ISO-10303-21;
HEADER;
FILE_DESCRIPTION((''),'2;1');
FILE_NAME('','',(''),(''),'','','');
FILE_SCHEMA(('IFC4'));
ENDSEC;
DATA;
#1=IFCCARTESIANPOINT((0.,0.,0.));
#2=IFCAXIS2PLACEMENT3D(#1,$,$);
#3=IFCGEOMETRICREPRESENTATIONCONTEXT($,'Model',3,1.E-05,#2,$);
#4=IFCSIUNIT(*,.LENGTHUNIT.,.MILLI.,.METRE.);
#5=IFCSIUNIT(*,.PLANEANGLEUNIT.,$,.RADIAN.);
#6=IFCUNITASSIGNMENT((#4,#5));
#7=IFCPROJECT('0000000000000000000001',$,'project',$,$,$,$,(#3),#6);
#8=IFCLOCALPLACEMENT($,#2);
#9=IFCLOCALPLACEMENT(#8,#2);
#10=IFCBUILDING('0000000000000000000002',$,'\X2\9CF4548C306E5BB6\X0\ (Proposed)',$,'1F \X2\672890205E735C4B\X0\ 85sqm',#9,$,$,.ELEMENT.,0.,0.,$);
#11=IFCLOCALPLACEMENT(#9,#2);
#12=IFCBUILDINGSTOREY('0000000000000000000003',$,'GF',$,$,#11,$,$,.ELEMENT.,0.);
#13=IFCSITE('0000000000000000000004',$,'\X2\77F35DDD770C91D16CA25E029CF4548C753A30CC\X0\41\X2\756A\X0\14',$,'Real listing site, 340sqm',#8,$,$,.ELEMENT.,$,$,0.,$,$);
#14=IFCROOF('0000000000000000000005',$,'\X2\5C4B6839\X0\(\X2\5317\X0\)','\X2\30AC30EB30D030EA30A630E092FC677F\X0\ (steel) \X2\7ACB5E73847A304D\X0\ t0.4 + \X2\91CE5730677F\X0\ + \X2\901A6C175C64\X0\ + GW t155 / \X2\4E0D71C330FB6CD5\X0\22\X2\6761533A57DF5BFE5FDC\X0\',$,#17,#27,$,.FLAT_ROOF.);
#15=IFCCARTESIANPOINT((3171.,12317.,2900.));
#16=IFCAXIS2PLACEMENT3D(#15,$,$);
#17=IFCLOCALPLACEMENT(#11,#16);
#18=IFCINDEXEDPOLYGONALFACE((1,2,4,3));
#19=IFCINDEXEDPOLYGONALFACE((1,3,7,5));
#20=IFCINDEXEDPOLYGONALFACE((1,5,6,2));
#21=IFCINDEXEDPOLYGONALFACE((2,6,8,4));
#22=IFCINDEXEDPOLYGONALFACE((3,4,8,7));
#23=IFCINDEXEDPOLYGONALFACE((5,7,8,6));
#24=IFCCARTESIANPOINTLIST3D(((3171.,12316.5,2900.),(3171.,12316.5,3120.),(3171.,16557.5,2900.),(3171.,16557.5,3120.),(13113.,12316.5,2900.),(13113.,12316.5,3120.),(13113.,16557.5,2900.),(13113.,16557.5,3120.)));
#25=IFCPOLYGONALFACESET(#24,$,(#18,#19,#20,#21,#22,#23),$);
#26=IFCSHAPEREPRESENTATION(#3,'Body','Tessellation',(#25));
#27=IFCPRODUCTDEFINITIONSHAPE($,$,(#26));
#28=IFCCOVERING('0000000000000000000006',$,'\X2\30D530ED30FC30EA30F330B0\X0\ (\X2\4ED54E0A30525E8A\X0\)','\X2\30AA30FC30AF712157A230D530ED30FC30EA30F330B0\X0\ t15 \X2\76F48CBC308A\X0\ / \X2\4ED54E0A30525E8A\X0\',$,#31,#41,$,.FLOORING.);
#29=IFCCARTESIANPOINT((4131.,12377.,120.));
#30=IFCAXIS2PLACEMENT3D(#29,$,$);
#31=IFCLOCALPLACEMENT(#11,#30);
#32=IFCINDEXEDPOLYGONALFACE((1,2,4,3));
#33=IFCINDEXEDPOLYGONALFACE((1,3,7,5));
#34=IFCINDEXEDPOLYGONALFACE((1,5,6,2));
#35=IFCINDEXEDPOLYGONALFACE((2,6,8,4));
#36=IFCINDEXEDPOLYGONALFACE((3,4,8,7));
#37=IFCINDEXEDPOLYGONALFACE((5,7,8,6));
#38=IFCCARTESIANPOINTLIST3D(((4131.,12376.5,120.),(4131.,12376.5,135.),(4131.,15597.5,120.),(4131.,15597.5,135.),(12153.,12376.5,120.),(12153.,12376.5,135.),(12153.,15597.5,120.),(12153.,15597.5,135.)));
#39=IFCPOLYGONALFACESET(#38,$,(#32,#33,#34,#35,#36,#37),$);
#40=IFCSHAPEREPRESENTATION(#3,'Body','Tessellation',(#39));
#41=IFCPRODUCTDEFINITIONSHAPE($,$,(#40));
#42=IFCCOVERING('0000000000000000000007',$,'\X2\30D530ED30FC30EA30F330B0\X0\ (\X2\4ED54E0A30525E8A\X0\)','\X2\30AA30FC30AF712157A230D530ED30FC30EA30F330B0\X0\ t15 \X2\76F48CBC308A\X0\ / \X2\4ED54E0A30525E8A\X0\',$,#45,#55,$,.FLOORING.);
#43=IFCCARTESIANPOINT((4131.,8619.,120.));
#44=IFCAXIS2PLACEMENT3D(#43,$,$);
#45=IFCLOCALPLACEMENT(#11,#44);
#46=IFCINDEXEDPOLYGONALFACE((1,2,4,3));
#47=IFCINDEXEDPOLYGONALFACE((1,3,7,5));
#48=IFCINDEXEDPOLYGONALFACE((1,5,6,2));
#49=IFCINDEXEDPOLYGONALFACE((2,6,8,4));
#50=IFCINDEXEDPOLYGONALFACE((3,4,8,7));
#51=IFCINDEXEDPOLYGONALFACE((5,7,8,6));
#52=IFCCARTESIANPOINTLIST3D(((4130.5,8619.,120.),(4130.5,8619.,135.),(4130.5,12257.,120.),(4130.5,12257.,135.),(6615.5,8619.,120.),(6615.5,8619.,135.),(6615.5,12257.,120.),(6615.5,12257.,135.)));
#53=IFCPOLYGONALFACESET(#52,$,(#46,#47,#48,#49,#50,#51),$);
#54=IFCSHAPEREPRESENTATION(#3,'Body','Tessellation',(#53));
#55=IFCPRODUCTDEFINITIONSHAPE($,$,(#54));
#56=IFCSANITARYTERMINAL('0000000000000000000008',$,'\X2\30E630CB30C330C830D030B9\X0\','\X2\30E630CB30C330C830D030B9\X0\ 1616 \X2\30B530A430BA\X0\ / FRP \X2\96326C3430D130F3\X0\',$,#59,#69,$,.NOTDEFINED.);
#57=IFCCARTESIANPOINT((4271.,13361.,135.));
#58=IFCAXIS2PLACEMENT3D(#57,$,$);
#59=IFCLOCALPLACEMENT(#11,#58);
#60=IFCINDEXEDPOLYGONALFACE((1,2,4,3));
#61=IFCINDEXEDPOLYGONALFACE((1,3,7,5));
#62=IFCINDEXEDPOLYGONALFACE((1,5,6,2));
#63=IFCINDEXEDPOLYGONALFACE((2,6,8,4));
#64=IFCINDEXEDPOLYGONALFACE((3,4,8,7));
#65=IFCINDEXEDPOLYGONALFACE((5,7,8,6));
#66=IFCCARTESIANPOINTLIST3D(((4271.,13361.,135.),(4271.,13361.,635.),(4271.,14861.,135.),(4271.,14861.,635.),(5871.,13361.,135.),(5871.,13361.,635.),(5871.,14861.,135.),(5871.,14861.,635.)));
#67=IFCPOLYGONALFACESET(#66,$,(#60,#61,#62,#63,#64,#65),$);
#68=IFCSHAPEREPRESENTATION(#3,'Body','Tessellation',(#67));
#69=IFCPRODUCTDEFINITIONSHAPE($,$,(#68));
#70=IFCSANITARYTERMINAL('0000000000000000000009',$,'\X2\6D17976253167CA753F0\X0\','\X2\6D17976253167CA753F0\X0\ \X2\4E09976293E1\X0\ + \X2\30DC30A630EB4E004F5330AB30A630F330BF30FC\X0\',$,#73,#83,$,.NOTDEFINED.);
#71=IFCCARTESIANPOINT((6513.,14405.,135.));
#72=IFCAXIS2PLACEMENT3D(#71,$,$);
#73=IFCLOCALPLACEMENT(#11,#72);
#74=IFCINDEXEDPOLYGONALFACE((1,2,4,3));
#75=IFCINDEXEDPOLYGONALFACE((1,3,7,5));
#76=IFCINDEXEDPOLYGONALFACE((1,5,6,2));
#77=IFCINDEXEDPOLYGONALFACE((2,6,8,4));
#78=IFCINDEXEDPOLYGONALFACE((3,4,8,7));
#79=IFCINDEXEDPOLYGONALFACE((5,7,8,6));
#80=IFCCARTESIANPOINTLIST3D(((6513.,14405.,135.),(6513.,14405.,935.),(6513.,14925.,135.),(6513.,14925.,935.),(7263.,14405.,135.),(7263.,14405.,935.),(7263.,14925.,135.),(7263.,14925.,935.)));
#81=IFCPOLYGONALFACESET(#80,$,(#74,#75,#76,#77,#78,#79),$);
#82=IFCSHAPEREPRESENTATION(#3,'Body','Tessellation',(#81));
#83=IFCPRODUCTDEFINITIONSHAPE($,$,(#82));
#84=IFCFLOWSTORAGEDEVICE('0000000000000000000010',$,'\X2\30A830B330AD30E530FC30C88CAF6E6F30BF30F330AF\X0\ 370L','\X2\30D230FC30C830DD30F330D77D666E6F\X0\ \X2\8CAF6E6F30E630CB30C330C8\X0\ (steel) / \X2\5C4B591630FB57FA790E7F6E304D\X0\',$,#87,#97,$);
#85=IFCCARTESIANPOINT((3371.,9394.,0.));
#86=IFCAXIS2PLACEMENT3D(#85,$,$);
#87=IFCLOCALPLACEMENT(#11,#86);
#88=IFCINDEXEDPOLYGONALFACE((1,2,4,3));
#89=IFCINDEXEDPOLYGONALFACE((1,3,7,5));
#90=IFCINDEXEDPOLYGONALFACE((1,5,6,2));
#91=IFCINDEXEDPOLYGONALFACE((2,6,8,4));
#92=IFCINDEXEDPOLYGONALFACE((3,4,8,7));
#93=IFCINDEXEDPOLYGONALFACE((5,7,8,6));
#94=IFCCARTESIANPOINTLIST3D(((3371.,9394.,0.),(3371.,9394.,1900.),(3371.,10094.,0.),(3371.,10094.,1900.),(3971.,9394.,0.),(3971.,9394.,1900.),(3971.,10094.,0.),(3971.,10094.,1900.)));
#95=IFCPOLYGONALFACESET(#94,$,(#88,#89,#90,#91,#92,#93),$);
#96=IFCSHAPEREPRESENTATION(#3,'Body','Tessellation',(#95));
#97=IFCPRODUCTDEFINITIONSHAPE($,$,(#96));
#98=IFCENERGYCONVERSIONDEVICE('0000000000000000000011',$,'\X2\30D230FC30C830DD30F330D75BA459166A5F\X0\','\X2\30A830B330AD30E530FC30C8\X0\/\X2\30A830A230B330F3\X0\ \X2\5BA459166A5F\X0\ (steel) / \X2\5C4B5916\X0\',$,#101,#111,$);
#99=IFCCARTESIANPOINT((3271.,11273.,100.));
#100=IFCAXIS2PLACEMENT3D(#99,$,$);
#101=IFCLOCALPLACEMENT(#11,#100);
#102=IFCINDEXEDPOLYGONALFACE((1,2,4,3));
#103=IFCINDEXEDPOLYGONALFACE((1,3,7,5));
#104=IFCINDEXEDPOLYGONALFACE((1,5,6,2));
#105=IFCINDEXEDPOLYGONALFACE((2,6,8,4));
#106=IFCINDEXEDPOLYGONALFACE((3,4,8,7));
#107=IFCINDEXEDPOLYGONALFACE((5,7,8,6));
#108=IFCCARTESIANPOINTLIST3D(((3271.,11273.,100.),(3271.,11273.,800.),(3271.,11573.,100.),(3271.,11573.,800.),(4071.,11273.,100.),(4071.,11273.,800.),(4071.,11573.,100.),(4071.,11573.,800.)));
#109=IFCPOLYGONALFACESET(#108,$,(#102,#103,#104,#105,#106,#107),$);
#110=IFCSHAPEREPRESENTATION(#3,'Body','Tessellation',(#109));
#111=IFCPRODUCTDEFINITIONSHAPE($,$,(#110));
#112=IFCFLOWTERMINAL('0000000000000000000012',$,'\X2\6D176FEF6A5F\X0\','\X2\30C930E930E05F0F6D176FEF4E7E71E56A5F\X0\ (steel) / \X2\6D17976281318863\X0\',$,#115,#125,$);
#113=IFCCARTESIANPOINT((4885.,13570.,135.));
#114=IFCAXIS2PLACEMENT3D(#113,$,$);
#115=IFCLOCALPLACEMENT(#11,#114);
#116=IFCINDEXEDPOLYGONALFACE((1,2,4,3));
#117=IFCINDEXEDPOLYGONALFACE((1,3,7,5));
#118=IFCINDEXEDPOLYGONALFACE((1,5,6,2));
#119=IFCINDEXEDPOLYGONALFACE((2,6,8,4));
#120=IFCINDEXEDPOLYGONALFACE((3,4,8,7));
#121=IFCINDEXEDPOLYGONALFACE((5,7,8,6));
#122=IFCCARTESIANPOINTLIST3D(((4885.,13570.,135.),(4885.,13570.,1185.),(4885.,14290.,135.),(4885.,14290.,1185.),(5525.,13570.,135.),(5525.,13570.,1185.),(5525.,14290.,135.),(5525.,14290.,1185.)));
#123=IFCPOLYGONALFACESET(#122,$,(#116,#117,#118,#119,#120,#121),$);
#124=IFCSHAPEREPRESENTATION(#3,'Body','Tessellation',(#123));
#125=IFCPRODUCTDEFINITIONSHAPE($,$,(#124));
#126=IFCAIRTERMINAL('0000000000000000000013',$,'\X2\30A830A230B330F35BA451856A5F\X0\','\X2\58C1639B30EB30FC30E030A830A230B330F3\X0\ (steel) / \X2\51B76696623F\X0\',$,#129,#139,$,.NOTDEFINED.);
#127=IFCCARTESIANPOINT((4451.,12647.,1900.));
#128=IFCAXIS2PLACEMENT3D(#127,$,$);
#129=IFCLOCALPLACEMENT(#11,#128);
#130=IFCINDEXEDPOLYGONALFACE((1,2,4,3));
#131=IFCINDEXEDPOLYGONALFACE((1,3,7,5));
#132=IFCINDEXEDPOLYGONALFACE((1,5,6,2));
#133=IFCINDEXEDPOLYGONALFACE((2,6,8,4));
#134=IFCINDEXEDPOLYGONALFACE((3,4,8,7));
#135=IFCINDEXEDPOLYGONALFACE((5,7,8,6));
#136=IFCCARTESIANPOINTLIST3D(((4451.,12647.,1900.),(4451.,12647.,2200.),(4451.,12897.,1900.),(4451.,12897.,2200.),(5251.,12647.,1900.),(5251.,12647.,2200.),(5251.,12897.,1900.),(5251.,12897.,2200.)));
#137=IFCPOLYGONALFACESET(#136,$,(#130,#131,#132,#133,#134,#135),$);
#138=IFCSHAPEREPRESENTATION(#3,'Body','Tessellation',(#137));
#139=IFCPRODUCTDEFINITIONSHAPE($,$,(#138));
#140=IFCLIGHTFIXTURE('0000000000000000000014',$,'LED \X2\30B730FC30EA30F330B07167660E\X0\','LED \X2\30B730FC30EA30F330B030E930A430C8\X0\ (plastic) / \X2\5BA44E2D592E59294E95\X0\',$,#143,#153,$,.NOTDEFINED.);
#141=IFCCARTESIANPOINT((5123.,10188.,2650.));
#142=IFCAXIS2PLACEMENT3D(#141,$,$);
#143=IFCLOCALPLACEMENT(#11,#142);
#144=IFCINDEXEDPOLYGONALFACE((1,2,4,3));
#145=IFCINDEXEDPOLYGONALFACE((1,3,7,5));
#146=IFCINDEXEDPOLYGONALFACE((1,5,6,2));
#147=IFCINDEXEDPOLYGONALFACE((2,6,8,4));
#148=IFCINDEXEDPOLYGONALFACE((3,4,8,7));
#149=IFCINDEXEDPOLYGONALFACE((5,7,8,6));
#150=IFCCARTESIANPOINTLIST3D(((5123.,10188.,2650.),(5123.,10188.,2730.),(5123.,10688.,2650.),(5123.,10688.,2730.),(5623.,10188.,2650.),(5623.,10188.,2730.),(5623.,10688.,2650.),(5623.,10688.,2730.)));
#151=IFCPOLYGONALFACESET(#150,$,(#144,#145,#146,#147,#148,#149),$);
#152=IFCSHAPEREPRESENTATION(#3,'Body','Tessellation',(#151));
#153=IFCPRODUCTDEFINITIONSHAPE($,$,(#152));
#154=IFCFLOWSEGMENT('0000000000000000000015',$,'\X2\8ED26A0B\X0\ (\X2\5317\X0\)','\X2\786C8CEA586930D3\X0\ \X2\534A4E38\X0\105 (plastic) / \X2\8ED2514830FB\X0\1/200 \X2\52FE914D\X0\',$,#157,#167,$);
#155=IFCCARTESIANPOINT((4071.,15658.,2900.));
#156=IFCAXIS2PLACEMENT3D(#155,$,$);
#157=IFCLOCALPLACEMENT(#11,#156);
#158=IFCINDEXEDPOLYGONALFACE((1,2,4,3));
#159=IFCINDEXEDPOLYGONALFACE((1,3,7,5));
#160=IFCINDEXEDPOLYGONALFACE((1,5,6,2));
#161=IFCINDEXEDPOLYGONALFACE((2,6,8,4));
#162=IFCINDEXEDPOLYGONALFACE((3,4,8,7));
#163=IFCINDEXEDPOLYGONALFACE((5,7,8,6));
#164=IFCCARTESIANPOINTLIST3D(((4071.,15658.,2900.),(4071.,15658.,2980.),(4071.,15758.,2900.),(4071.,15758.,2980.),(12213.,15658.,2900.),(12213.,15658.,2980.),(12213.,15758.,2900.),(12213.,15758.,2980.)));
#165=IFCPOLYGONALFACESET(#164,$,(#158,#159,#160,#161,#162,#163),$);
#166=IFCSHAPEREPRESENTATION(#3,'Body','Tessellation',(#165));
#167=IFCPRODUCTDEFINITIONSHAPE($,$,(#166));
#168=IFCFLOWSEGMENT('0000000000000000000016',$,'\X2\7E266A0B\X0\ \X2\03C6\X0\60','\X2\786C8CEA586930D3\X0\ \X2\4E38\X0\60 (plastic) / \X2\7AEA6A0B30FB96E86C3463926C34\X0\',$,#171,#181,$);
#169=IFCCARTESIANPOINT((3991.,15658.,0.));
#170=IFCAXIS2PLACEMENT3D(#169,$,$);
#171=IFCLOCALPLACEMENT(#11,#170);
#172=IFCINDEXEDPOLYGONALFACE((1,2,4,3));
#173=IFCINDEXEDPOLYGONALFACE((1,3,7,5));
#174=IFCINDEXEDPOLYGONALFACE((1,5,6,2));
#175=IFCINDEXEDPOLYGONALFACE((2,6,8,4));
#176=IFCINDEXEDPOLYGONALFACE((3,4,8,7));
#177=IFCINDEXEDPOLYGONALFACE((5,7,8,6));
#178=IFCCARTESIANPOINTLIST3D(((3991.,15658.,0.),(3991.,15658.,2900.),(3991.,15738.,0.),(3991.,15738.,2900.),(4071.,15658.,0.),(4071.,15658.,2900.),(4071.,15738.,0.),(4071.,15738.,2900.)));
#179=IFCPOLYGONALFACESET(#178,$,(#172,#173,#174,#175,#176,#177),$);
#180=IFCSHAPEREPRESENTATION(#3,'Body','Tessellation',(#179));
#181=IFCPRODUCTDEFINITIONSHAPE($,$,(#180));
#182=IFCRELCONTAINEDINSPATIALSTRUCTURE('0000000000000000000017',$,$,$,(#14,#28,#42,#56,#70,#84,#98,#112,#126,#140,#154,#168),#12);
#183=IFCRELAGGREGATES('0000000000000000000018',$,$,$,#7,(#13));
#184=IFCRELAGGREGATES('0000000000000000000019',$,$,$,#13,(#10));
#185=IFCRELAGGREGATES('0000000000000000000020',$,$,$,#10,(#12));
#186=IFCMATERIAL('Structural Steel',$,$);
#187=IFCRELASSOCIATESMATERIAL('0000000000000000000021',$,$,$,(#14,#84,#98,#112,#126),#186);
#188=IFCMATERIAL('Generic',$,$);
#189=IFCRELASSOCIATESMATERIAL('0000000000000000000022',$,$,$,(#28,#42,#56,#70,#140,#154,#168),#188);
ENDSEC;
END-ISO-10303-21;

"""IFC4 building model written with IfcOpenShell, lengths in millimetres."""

from ifc_helpers import new_model, si_unit, frame, frame_2d, origin, place, context, project, spatial, rectangle, extrude, material, element, save


model = new_model("IFC4")

# Units and contexts
model_context = context("Model", 3, precision=1e-05, world=origin())
ifc_project = project(units=[si_unit("LENGTHUNIT", "METRE", prefix="MILLI"), si_unit("PLANEANGLEUNIT", "RADIAN")], contexts=[model_context])

# Site, building, storey
site_placement = place(None, origin())
site = spatial("IfcSite", under=ifc_project, at=site_placement, Name="石川県金沢市鳴和町ヌ41番14", ObjectType="Real listing site, 340sqm", CompositionType="ELEMENT", RefElevation=0.0)
building_placement = place(site_placement, origin())
building = spatial("IfcBuilding", under=site, at=building_placement, Name="鳴和の家 (Proposed)", ObjectType="1F 木造平屋 85sqm", CompositionType="ELEMENT", ElevationOfRefHeight=0.0, ElevationOfTerrain=0.0)
storey_placement = place(building_placement, origin())
storey = spatial("IfcBuildingStorey", under=building, at=storey_placement, Name="GF", CompositionType="ELEMENT", Elevation=0.0)

# Roof
ifc_material_1 = material(Name="Structural Steel")
roof_placement = place(storey_placement, frame((3171.0, 12317.0, 2900.0)))
element("IfcRoof", 1, at=roof_placement, inside=storey, material=ifc_material_1, Name="屋根(北)", Description="ガルバリウム鋼板 (steel) 立平葺き t0.4 + 野地板 + 通気層 + GW t155 / 不燃・法22条区域対応", PredefinedType="FLAT_ROOF", context=model_context, shape_type="SweptSolid", body=[
    extrude(rectangle(XDim=9942.0, YDim=4241.0, at=frame_2d((4971.0, 2120.0))), frame((3171.0, 12317.0, 2900.0)), (0.0, 0.0, 1.0), 220.0),
])

# Coverings
ifc_material_2 = material(Name="Generic")
covering_1_placement = place(storey_placement, frame((4131.0, 12377.0, 120.0)))
element("IfcCovering", 2, at=covering_1_placement, inside=storey, material=ifc_material_2, Name="フローリング (仕上げ床)", Description="オーク無垢フローリング t15 直貼り / 仕上げ床", PredefinedType="FLOORING", context=model_context, shape_type="SweptSolid", body=[
    extrude(rectangle(XDim=8022.0, YDim=3221.0, at=frame_2d((4011.0, 1610.0))), frame((4131.0, 12377.0, 120.0)), (0.0, 0.0, 1.0), 15.0),
])
covering_2_placement = place(storey_placement, frame((4131.0, 8619.0, 120.0)))
element("IfcCovering", 3, at=covering_2_placement, inside=storey, material=ifc_material_2, Name="フローリング (仕上げ床)", Description="オーク無垢フローリング t15 直貼り / 仕上げ床", PredefinedType="FLOORING", context=model_context, shape_type="SweptSolid", body=[
    extrude(rectangle(XDim=2485.0, YDim=3638.0, at=frame_2d((1242.0, 1819.0))), frame((4131.0, 8619.0, 120.0)), (0.0, 0.0, 1.0), 15.0),
])

# Sanitary terminals
sanitary_terminal_1_placement = place(storey_placement, frame((4271.0, 13361.0, 135.0)))
element("IfcSanitaryTerminal", 4, at=sanitary_terminal_1_placement, inside=storey, material=ifc_material_2, Name="ユニットバス", Description="ユニットバス 1616 サイズ / FRP 防水パン", PredefinedType="NOTDEFINED", context=model_context, shape_type="SweptSolid", body=[
    extrude(rectangle(XDim=1600.0, YDim=1500.0, at=frame_2d((800.0, 750.0))), frame((4271.0, 13361.0, 135.0)), (0.0, 0.0, 1.0), 500.0),
])
sanitary_terminal_2_placement = place(storey_placement, frame((6513.0, 14405.0, 135.0)))
element("IfcSanitaryTerminal", 5, at=sanitary_terminal_2_placement, inside=storey, material=ifc_material_2, Name="洗面化粧台", Description="洗面化粧台 三面鏡 + ボウル一体カウンター", PredefinedType="NOTDEFINED", context=model_context, shape_type="SweptSolid", body=[
    extrude(rectangle(XDim=750.0, YDim=520.0, at=frame_2d((375.0, 260.0))), frame((6513.0, 14405.0, 135.0)), (0.0, 0.0, 1.0), 800.0),
])

# Flow storage device
flow_storage_device_placement = place(storey_placement, frame((3371.0, 9394.0, 0.0)))
element("IfcFlowStorageDevice", 6, at=flow_storage_device_placement, inside=storey, material=ifc_material_1, Name="エコキュート貯湯タンク 370L", Description="ヒートポンプ給湯 貯湯ユニット (steel) / 屋外・基礎置き", context=model_context, shape_type="SweptSolid", body=[
    extrude(rectangle(XDim=600.0, YDim=700.0, at=frame_2d((300.0, 350.0))), frame((3371.0, 9394.0, 0.0)), (0.0, 0.0, 1.0), 1900.0),
])

# Energy conversion device
energy_conversion_device_placement = place(storey_placement, frame((3271.0, 11273.0, 100.0)))
element("IfcEnergyConversionDevice", 7, at=energy_conversion_device_placement, inside=storey, material=ifc_material_1, Name="ヒートポンプ室外機", Description="エコキュート/エアコン 室外機 (steel) / 屋外", context=model_context, shape_type="SweptSolid", body=[
    extrude(rectangle(XDim=800.0, YDim=300.0, at=frame_2d((400.0, 150.0))), frame((3271.0, 11273.0, 100.0)), (0.0, 0.0, 1.0), 700.0),
])

# Flow terminal
flow_terminal_placement = place(storey_placement, frame((4885.0, 13570.0, 135.0)))
element("IfcFlowTerminal", 8, at=flow_terminal_placement, inside=storey, material=ifc_material_1, Name="洗濯機", Description="ドラム式洗濯乾燥機 (steel) / 洗面脱衣", context=model_context, shape_type="SweptSolid", body=[
    extrude(rectangle(XDim=640.0, YDim=720.0, at=frame_2d((320.0, 360.0))), frame((4885.0, 13570.0, 135.0)), (0.0, 0.0, 1.0), 1050.0),
])

# Air terminal
air_terminal_placement = place(storey_placement, frame((4451.0, 12647.0, 1900.0)))
element("IfcAirTerminal", 9, at=air_terminal_placement, inside=storey, material=ifc_material_1, Name="エアコン室内機", Description="壁掛ルームエアコン (steel) / 冷暖房", PredefinedType="NOTDEFINED", context=model_context, shape_type="SweptSolid", body=[
    extrude(rectangle(XDim=800.0, YDim=250.0, at=frame_2d((400.0, 125.0))), frame((4451.0, 12647.0, 1900.0)), (0.0, 0.0, 1.0), 300.0),
])

# Light fixture
light_fixture_placement = place(storey_placement, frame((5123.0, 10188.0, 2650.0)))
element("IfcLightFixture", 10, at=light_fixture_placement, inside=storey, material=ifc_material_2, Name="LED シーリング照明", Description="LED シーリングライト (plastic) / 室中央天井", PredefinedType="NOTDEFINED", context=model_context, shape_type="SweptSolid", body=[
    extrude(rectangle(XDim=500.0, YDim=500.0, at=frame_2d((250.0, 250.0))), frame((5123.0, 10188.0, 2650.0)), (0.0, 0.0, 1.0), 80.0),
])

# Flow segments
flow_segment_1_placement = place(storey_placement, frame((4071.0, 15658.0, 2900.0)))
element("IfcFlowSegment", 11, at=flow_segment_1_placement, inside=storey, material=ifc_material_2, Name="軒樋 (北)", Description="硬質塩ビ 半丸105 (plastic) / 軒先・1/200 勾配", context=model_context, shape_type="SweptSolid", body=[
    extrude(rectangle(XDim=8142.0, YDim=100.0, at=frame_2d((4071.0, 50.0))), frame((4071.0, 15658.0, 2900.0)), (0.0, 0.0, 1.0), 80.0),
])
flow_segment_2_placement = place(storey_placement, frame((3991.0, 15658.0, 0.0)))
element("IfcFlowSegment", 12, at=flow_segment_2_placement, inside=storey, material=ifc_material_2, Name="縦樋 φ60", Description="硬質塩ビ 丸60 (plastic) / 竪樋・雨水排水", context=model_context, shape_type="SweptSolid", body=[
    extrude(rectangle(XDim=80.0, YDim=80.0, at=frame_2d((40.0, 40.0))), frame((3991.0, 15658.0, 0.0)), (0.0, 0.0, 1.0), 2900.0),
])

save(model, "model.ifc")
